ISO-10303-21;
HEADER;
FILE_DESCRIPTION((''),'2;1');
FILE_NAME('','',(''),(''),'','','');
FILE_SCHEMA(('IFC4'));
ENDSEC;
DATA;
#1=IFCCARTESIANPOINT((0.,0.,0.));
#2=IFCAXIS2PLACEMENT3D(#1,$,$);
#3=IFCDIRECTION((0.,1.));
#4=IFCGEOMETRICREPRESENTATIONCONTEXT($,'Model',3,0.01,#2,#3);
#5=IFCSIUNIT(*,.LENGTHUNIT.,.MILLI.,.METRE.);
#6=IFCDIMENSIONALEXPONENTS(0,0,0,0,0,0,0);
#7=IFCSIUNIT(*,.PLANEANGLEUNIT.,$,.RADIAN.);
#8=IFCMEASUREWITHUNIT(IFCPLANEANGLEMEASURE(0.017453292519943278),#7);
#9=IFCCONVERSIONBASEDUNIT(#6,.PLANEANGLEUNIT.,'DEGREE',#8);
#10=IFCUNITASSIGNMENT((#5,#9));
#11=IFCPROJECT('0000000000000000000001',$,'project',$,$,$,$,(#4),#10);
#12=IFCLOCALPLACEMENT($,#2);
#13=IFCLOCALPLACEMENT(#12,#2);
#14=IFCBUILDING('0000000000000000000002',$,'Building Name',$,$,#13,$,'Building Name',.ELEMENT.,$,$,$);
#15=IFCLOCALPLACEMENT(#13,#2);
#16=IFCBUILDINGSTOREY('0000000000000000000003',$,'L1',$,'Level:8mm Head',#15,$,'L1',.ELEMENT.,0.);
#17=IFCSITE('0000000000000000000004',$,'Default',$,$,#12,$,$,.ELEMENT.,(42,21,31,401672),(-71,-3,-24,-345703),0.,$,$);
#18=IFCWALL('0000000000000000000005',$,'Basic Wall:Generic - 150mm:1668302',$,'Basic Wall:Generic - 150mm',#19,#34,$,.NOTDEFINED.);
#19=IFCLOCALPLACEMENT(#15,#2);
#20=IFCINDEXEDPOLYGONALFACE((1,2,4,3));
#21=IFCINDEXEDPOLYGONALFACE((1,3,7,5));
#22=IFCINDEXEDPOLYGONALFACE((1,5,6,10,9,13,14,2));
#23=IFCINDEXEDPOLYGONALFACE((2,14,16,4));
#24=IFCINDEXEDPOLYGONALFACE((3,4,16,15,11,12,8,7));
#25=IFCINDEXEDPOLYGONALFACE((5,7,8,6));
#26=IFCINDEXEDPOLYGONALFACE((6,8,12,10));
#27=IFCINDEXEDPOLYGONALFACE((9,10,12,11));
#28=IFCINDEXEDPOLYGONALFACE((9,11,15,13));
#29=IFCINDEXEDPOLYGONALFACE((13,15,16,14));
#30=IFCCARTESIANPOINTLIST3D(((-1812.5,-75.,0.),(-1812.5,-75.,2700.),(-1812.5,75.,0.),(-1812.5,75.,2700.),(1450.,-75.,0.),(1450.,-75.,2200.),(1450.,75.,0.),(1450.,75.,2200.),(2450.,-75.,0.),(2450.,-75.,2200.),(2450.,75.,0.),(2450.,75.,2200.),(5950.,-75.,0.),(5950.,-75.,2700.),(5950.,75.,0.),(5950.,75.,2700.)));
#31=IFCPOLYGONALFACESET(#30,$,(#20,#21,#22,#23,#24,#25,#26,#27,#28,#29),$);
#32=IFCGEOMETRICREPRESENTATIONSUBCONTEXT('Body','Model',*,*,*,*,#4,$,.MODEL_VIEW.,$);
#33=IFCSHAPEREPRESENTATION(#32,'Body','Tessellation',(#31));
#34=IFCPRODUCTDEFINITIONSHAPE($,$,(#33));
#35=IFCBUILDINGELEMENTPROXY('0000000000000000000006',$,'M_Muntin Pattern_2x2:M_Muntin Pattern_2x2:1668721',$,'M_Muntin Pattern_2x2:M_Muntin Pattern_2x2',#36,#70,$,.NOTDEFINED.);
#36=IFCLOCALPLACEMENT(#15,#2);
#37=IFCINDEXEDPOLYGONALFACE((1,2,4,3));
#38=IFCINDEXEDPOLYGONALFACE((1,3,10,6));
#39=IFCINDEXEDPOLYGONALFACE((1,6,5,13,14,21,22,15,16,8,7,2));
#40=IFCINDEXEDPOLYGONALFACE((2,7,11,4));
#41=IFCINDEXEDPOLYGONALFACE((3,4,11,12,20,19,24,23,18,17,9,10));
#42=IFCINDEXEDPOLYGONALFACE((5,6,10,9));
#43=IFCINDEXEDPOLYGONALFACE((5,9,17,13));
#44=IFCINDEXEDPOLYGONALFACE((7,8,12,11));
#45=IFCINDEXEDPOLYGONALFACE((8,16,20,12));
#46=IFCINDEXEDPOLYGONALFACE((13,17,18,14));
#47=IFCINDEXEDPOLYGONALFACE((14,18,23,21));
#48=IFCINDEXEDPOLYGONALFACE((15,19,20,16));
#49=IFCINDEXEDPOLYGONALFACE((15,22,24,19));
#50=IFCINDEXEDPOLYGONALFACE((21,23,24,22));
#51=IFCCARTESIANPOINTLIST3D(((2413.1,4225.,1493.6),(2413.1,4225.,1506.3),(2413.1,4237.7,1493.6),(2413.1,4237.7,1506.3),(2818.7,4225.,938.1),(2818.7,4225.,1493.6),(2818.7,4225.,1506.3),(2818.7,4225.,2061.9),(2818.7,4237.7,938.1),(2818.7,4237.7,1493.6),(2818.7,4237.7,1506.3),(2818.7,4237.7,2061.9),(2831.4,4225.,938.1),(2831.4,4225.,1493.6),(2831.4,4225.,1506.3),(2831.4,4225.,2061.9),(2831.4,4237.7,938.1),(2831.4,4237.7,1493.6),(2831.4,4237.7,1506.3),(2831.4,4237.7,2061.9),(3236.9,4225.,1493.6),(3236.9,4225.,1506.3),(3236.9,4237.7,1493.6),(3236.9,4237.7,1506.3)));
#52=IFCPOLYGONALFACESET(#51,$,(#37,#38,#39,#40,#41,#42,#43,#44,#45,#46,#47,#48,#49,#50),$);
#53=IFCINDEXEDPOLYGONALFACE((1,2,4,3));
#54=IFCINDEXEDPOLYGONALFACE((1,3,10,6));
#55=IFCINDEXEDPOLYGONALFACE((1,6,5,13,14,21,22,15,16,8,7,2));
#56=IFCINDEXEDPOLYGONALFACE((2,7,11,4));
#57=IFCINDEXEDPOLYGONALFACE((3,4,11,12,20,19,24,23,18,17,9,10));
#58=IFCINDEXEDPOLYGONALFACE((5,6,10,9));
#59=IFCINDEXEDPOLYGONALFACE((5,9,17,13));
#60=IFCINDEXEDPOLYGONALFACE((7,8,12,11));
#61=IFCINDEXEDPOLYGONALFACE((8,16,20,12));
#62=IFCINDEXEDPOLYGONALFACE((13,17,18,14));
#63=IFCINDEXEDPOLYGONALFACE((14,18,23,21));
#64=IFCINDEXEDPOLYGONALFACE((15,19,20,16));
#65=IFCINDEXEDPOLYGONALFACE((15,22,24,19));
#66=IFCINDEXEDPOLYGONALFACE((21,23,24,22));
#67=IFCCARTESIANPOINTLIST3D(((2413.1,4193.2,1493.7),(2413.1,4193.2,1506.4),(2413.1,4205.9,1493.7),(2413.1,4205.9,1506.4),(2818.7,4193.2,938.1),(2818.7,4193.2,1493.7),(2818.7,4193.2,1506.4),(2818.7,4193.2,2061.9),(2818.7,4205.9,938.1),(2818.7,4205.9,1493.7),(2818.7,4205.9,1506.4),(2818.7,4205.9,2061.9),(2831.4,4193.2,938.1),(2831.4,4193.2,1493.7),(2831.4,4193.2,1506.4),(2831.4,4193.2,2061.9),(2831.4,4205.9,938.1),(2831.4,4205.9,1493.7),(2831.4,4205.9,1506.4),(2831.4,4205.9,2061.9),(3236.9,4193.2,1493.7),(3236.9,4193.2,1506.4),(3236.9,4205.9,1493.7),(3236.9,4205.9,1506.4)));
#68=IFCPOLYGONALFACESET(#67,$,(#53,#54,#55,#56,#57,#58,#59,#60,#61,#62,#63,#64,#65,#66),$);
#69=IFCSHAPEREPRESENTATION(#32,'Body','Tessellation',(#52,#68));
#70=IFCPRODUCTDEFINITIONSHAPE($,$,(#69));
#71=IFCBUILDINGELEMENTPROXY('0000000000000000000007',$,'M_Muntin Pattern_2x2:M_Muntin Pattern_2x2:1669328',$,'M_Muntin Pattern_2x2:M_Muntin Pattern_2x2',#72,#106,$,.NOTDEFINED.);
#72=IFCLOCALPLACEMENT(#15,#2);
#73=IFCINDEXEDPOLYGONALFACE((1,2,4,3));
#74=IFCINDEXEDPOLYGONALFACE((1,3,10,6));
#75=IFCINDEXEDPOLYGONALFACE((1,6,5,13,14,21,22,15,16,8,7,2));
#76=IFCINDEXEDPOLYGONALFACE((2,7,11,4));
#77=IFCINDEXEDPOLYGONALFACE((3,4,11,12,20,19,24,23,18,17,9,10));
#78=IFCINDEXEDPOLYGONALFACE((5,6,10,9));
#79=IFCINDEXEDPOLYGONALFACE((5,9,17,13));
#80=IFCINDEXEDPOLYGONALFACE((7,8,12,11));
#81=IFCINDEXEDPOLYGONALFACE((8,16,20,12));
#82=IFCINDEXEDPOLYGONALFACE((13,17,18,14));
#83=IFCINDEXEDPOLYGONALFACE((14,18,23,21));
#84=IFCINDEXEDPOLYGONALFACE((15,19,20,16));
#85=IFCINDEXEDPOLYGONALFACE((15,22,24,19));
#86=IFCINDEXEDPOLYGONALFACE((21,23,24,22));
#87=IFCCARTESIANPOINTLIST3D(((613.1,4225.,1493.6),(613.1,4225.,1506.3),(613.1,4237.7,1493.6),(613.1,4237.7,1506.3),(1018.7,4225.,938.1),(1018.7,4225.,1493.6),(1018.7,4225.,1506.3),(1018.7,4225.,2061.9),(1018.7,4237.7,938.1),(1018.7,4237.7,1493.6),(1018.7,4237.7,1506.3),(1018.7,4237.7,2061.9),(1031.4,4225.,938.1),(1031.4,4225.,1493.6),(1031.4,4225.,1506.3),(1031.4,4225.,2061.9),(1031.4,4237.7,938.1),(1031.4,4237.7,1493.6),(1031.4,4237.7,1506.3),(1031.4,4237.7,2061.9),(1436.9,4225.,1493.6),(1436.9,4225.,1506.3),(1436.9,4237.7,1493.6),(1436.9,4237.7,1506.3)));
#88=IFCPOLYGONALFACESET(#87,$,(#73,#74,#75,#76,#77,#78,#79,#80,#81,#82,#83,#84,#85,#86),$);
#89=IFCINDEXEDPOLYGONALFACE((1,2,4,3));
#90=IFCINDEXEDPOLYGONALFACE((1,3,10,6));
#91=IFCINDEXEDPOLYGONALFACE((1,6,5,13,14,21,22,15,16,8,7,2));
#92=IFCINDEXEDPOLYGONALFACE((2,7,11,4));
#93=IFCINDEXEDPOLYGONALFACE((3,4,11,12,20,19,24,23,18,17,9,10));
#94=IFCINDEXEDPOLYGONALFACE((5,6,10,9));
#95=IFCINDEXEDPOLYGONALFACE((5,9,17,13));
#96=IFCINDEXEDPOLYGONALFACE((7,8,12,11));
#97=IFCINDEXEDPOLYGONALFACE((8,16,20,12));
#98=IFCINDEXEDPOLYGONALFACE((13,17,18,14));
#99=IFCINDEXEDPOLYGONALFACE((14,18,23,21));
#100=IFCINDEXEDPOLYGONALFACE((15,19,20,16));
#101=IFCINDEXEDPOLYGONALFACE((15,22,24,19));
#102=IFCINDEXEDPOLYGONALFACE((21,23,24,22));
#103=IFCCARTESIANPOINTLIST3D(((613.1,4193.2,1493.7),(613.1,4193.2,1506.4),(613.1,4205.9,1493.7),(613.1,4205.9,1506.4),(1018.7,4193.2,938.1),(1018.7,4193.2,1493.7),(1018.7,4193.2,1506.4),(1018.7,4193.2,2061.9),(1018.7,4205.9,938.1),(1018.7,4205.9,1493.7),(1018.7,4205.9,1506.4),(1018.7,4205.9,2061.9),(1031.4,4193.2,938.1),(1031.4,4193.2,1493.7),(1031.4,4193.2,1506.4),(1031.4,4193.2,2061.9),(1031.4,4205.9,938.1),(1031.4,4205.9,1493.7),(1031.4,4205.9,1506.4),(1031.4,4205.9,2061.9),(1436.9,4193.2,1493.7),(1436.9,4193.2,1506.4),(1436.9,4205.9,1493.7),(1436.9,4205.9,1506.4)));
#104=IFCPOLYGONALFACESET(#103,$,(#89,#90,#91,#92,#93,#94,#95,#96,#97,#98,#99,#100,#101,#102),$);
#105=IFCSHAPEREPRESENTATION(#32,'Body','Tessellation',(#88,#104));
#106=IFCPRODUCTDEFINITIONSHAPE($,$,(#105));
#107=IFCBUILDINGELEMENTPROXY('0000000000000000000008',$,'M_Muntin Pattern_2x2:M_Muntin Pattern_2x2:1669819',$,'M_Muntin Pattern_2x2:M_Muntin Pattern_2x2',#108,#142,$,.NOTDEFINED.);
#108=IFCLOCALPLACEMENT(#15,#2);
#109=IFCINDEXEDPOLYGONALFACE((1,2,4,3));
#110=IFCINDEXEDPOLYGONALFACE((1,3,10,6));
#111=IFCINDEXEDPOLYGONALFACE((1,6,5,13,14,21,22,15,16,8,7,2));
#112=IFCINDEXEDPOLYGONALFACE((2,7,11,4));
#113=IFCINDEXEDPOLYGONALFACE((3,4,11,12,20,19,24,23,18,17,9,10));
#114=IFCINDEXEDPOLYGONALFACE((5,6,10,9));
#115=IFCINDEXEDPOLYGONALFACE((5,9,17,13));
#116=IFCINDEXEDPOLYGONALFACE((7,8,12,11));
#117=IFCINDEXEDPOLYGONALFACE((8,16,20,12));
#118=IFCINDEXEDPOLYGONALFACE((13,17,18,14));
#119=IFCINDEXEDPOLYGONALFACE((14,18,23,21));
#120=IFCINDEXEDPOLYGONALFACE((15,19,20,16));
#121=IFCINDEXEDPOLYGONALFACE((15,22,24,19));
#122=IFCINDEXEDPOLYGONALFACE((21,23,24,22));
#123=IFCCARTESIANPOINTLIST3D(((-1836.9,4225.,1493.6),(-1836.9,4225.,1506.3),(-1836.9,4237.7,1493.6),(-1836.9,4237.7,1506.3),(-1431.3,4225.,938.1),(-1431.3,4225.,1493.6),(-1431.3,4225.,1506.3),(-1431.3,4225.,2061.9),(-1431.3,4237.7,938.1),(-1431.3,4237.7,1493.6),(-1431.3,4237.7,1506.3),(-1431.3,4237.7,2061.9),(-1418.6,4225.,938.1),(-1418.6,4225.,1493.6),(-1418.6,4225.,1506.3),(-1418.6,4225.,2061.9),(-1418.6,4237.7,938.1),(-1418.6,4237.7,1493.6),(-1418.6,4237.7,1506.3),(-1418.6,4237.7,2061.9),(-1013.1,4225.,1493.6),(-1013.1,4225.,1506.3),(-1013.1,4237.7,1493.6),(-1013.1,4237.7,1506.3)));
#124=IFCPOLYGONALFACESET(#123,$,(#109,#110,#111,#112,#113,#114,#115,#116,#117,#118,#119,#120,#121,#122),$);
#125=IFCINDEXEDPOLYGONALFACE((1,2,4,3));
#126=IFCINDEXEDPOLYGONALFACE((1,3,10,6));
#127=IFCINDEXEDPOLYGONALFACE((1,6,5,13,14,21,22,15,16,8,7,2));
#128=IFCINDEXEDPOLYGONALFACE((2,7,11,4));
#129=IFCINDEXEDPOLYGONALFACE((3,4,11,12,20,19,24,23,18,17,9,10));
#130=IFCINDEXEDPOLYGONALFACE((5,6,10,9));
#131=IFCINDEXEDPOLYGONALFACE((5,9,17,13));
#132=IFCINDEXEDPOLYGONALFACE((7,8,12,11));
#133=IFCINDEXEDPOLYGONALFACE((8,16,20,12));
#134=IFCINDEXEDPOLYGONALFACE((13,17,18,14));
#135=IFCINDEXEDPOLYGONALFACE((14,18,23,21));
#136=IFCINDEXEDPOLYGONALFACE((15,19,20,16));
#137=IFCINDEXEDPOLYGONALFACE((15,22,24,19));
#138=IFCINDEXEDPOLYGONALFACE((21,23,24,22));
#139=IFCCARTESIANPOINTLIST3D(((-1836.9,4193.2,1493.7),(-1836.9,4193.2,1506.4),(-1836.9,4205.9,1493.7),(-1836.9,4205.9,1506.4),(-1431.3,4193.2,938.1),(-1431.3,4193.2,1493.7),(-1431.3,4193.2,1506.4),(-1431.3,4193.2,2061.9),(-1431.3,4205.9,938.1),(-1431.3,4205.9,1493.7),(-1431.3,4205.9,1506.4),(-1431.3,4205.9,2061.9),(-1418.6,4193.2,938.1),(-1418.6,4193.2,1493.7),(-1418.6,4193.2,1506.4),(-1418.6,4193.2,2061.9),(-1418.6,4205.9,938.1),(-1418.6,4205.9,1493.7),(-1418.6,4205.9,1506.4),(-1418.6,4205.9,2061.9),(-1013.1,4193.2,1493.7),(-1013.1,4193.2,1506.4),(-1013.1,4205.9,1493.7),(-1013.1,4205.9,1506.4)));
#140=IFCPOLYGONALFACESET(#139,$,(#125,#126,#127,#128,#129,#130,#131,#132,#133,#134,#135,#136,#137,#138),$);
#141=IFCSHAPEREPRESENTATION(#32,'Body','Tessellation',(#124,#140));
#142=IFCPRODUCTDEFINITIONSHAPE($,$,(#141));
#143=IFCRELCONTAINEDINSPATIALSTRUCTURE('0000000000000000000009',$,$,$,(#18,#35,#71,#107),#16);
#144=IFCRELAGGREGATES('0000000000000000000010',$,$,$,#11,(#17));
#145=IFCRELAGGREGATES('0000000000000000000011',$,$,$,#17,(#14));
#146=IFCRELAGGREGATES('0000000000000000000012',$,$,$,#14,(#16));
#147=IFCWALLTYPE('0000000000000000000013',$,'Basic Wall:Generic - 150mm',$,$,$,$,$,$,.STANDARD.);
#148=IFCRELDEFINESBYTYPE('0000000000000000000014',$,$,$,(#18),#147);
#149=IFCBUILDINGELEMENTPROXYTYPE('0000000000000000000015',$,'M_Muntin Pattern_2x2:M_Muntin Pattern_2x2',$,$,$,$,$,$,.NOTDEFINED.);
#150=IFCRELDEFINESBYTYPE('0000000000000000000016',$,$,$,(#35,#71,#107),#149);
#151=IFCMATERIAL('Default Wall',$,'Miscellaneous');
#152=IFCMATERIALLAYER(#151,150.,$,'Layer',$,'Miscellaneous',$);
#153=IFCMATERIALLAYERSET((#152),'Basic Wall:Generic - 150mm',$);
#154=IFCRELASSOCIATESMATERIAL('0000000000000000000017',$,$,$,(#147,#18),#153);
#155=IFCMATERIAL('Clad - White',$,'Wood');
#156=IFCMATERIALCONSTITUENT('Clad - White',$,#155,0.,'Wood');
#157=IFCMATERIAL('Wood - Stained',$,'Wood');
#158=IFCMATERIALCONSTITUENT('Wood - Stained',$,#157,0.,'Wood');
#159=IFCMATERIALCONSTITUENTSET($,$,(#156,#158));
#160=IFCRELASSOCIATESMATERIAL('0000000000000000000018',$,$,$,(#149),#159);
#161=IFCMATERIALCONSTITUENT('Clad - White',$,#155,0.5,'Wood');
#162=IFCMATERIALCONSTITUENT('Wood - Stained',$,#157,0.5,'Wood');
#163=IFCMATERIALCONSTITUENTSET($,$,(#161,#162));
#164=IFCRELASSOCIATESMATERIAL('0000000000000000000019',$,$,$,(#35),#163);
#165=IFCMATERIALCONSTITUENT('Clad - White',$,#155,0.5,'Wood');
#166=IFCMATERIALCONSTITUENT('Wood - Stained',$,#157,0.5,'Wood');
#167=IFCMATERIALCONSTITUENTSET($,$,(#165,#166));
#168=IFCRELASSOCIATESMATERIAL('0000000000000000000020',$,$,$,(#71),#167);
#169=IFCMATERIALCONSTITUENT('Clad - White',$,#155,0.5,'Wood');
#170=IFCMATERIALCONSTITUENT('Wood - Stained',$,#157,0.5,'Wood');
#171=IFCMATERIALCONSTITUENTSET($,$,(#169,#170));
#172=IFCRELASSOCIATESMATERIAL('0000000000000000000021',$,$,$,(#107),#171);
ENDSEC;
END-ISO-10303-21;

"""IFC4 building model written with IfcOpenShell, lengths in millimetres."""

from ifc_helpers import new_model, entity, si_unit, converted_unit, direction, frame, frame_2d, origin, place, context, subcontext, project, spatial, polyline, rectangle, outline, extrude, source, transform, mapped, material, layer, layer_set, layer_usage, constituent, constituent_set, type_object, type_shapes, element, save


model = new_model("IFC4")

# Units and contexts
model_context = context("Model", 3, precision=0.01, world=origin(), true_north=direction((0.0, 1.0)))
body_context = subcontext(model_context, "Body", "Model", "MODEL_VIEW")
ifc_project = project(units=[si_unit("LENGTHUNIT", "METRE", prefix="MILLI"), converted_unit("PLANEANGLEUNIT", "DEGREE", entity("IfcPlaneAngleMeasure", 0.017453292519943278), si_unit("PLANEANGLEUNIT", "RADIAN"), dimensions=[0, 0, 0, 0, 0, 0, 0])], contexts=[model_context])

# Site, building, storey
site_placement = place(None, origin())
site = spatial("IfcSite", under=ifc_project, at=site_placement, Name="Default", CompositionType="ELEMENT", RefLatitude=(42, 21, 31, 401672), RefLongitude=(-71, -3, -24, -345703), RefElevation=0.0)
building_placement = place(site_placement, origin())
building = spatial("IfcBuilding", under=site, at=building_placement, Name="Building Name", LongName="Building Name", CompositionType="ELEMENT")
storey_placement = place(building_placement, origin())
storey = spatial("IfcBuildingStorey", under=building, at=storey_placement, Name="L1", ObjectType="Level:8mm Head", LongName="L1", CompositionType="ELEMENT", Elevation=0.0)

# Shared definitions
ifc_material_1 = material(Name="Default Wall", Category="Miscellaneous")
ifc_layer_1 = layer(ifc_material_1, 150.0, Name="Layer", Category="Miscellaneous")
ifc_layer_set_1 = layer_set([ifc_layer_1], Name="Basic Wall:Generic - 150mm")
wall_type = type_object("IfcWallType", Name="Basic Wall:Generic - 150mm", PredefinedType="STANDARD", material=ifc_layer_set_1)

# Wall, openings
ifc_layer_usage_1 = layer_usage(ifc_layer_set_1, "AXIS2", "NEGATIVE", 75.0)
wall_1_placement = place(storey_placement, frame((5950.0, 0.0, 0.0), z_axis=(0.0, 0.0, 1.0), x_axis=(-1.0, 0.0, 0.0)))
wall_1 = element("IfcWall", 1, at=wall_1_placement, inside=storey, type_object=wall_type, material=ifc_layer_usage_1, Name="Basic Wall:Generic - 150mm:1668302", ObjectType="Basic Wall:Generic - 150mm", PredefinedType="NOTDEFINED", context=body_context, shape_type="SweptSolid", body=[
    extrude(rectangle(XDim=7762.5, YDim=150.0, at=frame_2d((3881.2, 0.0), x_axis=(1.0, 0.0))), origin(), (0.0, 0.0, 1.0), 2700.0),
])
opening_1_placement = place(wall_1_placement, frame((4500.0, 75.0, 0.0)))
element("IfcOpeningElement", 2, at=opening_1_placement, cuts=wall_1, PredefinedType="OPENING", context=body_context, shape_type="SweptSolid", body=[
    extrude(rectangle(XDim=2200.0, YDim=1000.0, at=frame_2d((1100.0, 500.0), x_axis=(1.0, 0.0))), frame((0.0, 0.0, 0.0), z_axis=(0.0, -1.0, 0.0), x_axis=(0.0, 0.0, 1.0)), (0.0, 0.0, 1.0), 150.0),
])
opening_2_placement = place(wall_1_placement, frame((5950.0, 0.0, 0.0), z_axis=(0.0, 0.0, 1.0), x_axis=(-1.0, 0.0, 0.0)))
element("IfcOpeningElement", 3, at=opening_2_placement, cuts=wall_1, PredefinedType="OPENING", context=body_context, shape_type="SweptSolid", body=[
    extrude(rectangle(XDim=2200.0, YDim=1000.0, at=frame_2d((0.0, 0.0), x_axis=(1.0, 0.0))), frame((1950.0, 1449.0, 1100.0), z_axis=(0.0, -1.0, 0.0), x_axis=(0.0, 0.0, 1.0)), (0.0, 0.0, 1.0), 3048.0),
])

# Building element proxies
ifc_material_2 = material(Name="Clad - White", Category="Wood")
ifc_constituent_1 = constituent(ifc_material_2, Name="Clad - White", Category="Wood", fraction=0.5)
ifc_material_3 = material(Name="Wood - Stained", Category="Wood")
ifc_constituent_2 = constituent(ifc_material_3, Name="Wood - Stained", Category="Wood", fraction=0.5)
ifc_constituent_set_1 = constituent_set(constituents=[ifc_constituent_1, ifc_constituent_2])
ifc_constituent_3 = constituent(ifc_material_2, Name="Clad - White", Category="Wood", fraction=0.0)
ifc_constituent_4 = constituent(ifc_material_3, Name="Wood - Stained", Category="Wood", fraction=0.0)
ifc_constituent_set_2 = constituent_set(constituents=[ifc_constituent_3, ifc_constituent_4])
building_element_proxy_type_1 = type_object("IfcBuildingElementProxyType", Name="M_Muntin Pattern_2x2:M_Muntin Pattern_2x2", PredefinedType="NOTDEFINED", material=ifc_constituent_set_2)
shared_shape_1 = source(origin(), body_context, "Body", "SweptSolid", [
    extrude(outline(polyline([(6.4, -6.4), (561.9, -6.4), (561.9, 6.3), (6.4, 6.3), (6.4, 411.9), (-6.3, 411.9), (-6.3, 6.3), (-561.9, 6.3), (-561.9, -6.4), (-6.3, -6.4), (-6.3, -411.9), (6.4, -411.9), (6.4, -6.4)])), frame((0.0, -22.2, 561.9), z_axis=(0.0, 1.0, 0.0), x_axis=(0.0, 0.0, 1.0)), (0.0, 0.0, 1.0), 12.7),
    extrude(outline(polyline([(6.4, -6.4), (561.9, -6.4), (561.9, 6.3), (6.4, 6.3), (6.4, 411.9), (-6.3, 411.9), (-6.3, 6.3), (-561.9, 6.3), (-561.9, -6.4), (-6.3, -6.4), (-6.3, -411.9), (6.4, -411.9), (6.4, -6.4)])), frame((0.0, 9.5, 561.9), z_axis=(0.0, 1.0, 0.0), x_axis=(0.0, 0.0, 1.0)), (0.0, 0.0, 1.0), 12.7),
])
type_shapes(building_element_proxy_type_1, [shared_shape_1])
proxy_1_placement = place(storey_placement, frame((2825.0, 4215.5, 938.1), z_axis=(0.0, 0.0, 1.0), x_axis=(-1.0, 0.0, 0.0)))
element("IfcBuildingElementProxy", 4, at=proxy_1_placement, inside=storey, type_object=building_element_proxy_type_1, material=ifc_constituent_set_1, Name="M_Muntin Pattern_2x2:M_Muntin Pattern_2x2:1668721", ObjectType="M_Muntin Pattern_2x2:M_Muntin Pattern_2x2", PredefinedType="NOTDEFINED", context=body_context, shape_type="MappedRepresentation", body=[
    mapped(shared_shape_1, transform((0.0, 0.0, 0.0), scale=1.0)),
])
ifc_constituent_5 = constituent(ifc_material_2, Name="Clad - White", Category="Wood", fraction=0.5)
ifc_constituent_6 = constituent(ifc_material_3, Name="Wood - Stained", Category="Wood", fraction=0.5)
ifc_constituent_set_3 = constituent_set(constituents=[ifc_constituent_5, ifc_constituent_6])
proxy_2_placement = place(storey_placement, frame((1025.0, 4215.5, 938.1), z_axis=(0.0, 0.0, 1.0), x_axis=(-1.0, 0.0, 0.0)))
element("IfcBuildingElementProxy", 5, at=proxy_2_placement, inside=storey, type_object=building_element_proxy_type_1, material=ifc_constituent_set_3, Name="M_Muntin Pattern_2x2:M_Muntin Pattern_2x2:1669328", ObjectType="M_Muntin Pattern_2x2:M_Muntin Pattern_2x2", PredefinedType="NOTDEFINED", context=body_context, shape_type="MappedRepresentation", body=[
    mapped(shared_shape_1, transform((0.0, 0.0, 0.0), scale=1.0)),
])
ifc_constituent_7 = constituent(ifc_material_2, Name="Clad - White", Category="Wood", fraction=0.5)
ifc_constituent_8 = constituent(ifc_material_3, Name="Wood - Stained", Category="Wood", fraction=0.5)
ifc_constituent_set_4 = constituent_set(constituents=[ifc_constituent_7, ifc_constituent_8])
proxy_3_placement = place(storey_placement, frame((-1425.0, 4215.5, 938.1), z_axis=(0.0, 0.0, 1.0), x_axis=(-1.0, 0.0, 0.0)))
element("IfcBuildingElementProxy", 6, at=proxy_3_placement, inside=storey, type_object=building_element_proxy_type_1, material=ifc_constituent_set_4, Name="M_Muntin Pattern_2x2:M_Muntin Pattern_2x2:1669819", ObjectType="M_Muntin Pattern_2x2:M_Muntin Pattern_2x2", PredefinedType="NOTDEFINED", context=body_context, shape_type="MappedRepresentation", body=[
    mapped(shared_shape_1, transform((0.0, 0.0, 0.0), scale=1.0)),
])

save(model, "model.ifc")
